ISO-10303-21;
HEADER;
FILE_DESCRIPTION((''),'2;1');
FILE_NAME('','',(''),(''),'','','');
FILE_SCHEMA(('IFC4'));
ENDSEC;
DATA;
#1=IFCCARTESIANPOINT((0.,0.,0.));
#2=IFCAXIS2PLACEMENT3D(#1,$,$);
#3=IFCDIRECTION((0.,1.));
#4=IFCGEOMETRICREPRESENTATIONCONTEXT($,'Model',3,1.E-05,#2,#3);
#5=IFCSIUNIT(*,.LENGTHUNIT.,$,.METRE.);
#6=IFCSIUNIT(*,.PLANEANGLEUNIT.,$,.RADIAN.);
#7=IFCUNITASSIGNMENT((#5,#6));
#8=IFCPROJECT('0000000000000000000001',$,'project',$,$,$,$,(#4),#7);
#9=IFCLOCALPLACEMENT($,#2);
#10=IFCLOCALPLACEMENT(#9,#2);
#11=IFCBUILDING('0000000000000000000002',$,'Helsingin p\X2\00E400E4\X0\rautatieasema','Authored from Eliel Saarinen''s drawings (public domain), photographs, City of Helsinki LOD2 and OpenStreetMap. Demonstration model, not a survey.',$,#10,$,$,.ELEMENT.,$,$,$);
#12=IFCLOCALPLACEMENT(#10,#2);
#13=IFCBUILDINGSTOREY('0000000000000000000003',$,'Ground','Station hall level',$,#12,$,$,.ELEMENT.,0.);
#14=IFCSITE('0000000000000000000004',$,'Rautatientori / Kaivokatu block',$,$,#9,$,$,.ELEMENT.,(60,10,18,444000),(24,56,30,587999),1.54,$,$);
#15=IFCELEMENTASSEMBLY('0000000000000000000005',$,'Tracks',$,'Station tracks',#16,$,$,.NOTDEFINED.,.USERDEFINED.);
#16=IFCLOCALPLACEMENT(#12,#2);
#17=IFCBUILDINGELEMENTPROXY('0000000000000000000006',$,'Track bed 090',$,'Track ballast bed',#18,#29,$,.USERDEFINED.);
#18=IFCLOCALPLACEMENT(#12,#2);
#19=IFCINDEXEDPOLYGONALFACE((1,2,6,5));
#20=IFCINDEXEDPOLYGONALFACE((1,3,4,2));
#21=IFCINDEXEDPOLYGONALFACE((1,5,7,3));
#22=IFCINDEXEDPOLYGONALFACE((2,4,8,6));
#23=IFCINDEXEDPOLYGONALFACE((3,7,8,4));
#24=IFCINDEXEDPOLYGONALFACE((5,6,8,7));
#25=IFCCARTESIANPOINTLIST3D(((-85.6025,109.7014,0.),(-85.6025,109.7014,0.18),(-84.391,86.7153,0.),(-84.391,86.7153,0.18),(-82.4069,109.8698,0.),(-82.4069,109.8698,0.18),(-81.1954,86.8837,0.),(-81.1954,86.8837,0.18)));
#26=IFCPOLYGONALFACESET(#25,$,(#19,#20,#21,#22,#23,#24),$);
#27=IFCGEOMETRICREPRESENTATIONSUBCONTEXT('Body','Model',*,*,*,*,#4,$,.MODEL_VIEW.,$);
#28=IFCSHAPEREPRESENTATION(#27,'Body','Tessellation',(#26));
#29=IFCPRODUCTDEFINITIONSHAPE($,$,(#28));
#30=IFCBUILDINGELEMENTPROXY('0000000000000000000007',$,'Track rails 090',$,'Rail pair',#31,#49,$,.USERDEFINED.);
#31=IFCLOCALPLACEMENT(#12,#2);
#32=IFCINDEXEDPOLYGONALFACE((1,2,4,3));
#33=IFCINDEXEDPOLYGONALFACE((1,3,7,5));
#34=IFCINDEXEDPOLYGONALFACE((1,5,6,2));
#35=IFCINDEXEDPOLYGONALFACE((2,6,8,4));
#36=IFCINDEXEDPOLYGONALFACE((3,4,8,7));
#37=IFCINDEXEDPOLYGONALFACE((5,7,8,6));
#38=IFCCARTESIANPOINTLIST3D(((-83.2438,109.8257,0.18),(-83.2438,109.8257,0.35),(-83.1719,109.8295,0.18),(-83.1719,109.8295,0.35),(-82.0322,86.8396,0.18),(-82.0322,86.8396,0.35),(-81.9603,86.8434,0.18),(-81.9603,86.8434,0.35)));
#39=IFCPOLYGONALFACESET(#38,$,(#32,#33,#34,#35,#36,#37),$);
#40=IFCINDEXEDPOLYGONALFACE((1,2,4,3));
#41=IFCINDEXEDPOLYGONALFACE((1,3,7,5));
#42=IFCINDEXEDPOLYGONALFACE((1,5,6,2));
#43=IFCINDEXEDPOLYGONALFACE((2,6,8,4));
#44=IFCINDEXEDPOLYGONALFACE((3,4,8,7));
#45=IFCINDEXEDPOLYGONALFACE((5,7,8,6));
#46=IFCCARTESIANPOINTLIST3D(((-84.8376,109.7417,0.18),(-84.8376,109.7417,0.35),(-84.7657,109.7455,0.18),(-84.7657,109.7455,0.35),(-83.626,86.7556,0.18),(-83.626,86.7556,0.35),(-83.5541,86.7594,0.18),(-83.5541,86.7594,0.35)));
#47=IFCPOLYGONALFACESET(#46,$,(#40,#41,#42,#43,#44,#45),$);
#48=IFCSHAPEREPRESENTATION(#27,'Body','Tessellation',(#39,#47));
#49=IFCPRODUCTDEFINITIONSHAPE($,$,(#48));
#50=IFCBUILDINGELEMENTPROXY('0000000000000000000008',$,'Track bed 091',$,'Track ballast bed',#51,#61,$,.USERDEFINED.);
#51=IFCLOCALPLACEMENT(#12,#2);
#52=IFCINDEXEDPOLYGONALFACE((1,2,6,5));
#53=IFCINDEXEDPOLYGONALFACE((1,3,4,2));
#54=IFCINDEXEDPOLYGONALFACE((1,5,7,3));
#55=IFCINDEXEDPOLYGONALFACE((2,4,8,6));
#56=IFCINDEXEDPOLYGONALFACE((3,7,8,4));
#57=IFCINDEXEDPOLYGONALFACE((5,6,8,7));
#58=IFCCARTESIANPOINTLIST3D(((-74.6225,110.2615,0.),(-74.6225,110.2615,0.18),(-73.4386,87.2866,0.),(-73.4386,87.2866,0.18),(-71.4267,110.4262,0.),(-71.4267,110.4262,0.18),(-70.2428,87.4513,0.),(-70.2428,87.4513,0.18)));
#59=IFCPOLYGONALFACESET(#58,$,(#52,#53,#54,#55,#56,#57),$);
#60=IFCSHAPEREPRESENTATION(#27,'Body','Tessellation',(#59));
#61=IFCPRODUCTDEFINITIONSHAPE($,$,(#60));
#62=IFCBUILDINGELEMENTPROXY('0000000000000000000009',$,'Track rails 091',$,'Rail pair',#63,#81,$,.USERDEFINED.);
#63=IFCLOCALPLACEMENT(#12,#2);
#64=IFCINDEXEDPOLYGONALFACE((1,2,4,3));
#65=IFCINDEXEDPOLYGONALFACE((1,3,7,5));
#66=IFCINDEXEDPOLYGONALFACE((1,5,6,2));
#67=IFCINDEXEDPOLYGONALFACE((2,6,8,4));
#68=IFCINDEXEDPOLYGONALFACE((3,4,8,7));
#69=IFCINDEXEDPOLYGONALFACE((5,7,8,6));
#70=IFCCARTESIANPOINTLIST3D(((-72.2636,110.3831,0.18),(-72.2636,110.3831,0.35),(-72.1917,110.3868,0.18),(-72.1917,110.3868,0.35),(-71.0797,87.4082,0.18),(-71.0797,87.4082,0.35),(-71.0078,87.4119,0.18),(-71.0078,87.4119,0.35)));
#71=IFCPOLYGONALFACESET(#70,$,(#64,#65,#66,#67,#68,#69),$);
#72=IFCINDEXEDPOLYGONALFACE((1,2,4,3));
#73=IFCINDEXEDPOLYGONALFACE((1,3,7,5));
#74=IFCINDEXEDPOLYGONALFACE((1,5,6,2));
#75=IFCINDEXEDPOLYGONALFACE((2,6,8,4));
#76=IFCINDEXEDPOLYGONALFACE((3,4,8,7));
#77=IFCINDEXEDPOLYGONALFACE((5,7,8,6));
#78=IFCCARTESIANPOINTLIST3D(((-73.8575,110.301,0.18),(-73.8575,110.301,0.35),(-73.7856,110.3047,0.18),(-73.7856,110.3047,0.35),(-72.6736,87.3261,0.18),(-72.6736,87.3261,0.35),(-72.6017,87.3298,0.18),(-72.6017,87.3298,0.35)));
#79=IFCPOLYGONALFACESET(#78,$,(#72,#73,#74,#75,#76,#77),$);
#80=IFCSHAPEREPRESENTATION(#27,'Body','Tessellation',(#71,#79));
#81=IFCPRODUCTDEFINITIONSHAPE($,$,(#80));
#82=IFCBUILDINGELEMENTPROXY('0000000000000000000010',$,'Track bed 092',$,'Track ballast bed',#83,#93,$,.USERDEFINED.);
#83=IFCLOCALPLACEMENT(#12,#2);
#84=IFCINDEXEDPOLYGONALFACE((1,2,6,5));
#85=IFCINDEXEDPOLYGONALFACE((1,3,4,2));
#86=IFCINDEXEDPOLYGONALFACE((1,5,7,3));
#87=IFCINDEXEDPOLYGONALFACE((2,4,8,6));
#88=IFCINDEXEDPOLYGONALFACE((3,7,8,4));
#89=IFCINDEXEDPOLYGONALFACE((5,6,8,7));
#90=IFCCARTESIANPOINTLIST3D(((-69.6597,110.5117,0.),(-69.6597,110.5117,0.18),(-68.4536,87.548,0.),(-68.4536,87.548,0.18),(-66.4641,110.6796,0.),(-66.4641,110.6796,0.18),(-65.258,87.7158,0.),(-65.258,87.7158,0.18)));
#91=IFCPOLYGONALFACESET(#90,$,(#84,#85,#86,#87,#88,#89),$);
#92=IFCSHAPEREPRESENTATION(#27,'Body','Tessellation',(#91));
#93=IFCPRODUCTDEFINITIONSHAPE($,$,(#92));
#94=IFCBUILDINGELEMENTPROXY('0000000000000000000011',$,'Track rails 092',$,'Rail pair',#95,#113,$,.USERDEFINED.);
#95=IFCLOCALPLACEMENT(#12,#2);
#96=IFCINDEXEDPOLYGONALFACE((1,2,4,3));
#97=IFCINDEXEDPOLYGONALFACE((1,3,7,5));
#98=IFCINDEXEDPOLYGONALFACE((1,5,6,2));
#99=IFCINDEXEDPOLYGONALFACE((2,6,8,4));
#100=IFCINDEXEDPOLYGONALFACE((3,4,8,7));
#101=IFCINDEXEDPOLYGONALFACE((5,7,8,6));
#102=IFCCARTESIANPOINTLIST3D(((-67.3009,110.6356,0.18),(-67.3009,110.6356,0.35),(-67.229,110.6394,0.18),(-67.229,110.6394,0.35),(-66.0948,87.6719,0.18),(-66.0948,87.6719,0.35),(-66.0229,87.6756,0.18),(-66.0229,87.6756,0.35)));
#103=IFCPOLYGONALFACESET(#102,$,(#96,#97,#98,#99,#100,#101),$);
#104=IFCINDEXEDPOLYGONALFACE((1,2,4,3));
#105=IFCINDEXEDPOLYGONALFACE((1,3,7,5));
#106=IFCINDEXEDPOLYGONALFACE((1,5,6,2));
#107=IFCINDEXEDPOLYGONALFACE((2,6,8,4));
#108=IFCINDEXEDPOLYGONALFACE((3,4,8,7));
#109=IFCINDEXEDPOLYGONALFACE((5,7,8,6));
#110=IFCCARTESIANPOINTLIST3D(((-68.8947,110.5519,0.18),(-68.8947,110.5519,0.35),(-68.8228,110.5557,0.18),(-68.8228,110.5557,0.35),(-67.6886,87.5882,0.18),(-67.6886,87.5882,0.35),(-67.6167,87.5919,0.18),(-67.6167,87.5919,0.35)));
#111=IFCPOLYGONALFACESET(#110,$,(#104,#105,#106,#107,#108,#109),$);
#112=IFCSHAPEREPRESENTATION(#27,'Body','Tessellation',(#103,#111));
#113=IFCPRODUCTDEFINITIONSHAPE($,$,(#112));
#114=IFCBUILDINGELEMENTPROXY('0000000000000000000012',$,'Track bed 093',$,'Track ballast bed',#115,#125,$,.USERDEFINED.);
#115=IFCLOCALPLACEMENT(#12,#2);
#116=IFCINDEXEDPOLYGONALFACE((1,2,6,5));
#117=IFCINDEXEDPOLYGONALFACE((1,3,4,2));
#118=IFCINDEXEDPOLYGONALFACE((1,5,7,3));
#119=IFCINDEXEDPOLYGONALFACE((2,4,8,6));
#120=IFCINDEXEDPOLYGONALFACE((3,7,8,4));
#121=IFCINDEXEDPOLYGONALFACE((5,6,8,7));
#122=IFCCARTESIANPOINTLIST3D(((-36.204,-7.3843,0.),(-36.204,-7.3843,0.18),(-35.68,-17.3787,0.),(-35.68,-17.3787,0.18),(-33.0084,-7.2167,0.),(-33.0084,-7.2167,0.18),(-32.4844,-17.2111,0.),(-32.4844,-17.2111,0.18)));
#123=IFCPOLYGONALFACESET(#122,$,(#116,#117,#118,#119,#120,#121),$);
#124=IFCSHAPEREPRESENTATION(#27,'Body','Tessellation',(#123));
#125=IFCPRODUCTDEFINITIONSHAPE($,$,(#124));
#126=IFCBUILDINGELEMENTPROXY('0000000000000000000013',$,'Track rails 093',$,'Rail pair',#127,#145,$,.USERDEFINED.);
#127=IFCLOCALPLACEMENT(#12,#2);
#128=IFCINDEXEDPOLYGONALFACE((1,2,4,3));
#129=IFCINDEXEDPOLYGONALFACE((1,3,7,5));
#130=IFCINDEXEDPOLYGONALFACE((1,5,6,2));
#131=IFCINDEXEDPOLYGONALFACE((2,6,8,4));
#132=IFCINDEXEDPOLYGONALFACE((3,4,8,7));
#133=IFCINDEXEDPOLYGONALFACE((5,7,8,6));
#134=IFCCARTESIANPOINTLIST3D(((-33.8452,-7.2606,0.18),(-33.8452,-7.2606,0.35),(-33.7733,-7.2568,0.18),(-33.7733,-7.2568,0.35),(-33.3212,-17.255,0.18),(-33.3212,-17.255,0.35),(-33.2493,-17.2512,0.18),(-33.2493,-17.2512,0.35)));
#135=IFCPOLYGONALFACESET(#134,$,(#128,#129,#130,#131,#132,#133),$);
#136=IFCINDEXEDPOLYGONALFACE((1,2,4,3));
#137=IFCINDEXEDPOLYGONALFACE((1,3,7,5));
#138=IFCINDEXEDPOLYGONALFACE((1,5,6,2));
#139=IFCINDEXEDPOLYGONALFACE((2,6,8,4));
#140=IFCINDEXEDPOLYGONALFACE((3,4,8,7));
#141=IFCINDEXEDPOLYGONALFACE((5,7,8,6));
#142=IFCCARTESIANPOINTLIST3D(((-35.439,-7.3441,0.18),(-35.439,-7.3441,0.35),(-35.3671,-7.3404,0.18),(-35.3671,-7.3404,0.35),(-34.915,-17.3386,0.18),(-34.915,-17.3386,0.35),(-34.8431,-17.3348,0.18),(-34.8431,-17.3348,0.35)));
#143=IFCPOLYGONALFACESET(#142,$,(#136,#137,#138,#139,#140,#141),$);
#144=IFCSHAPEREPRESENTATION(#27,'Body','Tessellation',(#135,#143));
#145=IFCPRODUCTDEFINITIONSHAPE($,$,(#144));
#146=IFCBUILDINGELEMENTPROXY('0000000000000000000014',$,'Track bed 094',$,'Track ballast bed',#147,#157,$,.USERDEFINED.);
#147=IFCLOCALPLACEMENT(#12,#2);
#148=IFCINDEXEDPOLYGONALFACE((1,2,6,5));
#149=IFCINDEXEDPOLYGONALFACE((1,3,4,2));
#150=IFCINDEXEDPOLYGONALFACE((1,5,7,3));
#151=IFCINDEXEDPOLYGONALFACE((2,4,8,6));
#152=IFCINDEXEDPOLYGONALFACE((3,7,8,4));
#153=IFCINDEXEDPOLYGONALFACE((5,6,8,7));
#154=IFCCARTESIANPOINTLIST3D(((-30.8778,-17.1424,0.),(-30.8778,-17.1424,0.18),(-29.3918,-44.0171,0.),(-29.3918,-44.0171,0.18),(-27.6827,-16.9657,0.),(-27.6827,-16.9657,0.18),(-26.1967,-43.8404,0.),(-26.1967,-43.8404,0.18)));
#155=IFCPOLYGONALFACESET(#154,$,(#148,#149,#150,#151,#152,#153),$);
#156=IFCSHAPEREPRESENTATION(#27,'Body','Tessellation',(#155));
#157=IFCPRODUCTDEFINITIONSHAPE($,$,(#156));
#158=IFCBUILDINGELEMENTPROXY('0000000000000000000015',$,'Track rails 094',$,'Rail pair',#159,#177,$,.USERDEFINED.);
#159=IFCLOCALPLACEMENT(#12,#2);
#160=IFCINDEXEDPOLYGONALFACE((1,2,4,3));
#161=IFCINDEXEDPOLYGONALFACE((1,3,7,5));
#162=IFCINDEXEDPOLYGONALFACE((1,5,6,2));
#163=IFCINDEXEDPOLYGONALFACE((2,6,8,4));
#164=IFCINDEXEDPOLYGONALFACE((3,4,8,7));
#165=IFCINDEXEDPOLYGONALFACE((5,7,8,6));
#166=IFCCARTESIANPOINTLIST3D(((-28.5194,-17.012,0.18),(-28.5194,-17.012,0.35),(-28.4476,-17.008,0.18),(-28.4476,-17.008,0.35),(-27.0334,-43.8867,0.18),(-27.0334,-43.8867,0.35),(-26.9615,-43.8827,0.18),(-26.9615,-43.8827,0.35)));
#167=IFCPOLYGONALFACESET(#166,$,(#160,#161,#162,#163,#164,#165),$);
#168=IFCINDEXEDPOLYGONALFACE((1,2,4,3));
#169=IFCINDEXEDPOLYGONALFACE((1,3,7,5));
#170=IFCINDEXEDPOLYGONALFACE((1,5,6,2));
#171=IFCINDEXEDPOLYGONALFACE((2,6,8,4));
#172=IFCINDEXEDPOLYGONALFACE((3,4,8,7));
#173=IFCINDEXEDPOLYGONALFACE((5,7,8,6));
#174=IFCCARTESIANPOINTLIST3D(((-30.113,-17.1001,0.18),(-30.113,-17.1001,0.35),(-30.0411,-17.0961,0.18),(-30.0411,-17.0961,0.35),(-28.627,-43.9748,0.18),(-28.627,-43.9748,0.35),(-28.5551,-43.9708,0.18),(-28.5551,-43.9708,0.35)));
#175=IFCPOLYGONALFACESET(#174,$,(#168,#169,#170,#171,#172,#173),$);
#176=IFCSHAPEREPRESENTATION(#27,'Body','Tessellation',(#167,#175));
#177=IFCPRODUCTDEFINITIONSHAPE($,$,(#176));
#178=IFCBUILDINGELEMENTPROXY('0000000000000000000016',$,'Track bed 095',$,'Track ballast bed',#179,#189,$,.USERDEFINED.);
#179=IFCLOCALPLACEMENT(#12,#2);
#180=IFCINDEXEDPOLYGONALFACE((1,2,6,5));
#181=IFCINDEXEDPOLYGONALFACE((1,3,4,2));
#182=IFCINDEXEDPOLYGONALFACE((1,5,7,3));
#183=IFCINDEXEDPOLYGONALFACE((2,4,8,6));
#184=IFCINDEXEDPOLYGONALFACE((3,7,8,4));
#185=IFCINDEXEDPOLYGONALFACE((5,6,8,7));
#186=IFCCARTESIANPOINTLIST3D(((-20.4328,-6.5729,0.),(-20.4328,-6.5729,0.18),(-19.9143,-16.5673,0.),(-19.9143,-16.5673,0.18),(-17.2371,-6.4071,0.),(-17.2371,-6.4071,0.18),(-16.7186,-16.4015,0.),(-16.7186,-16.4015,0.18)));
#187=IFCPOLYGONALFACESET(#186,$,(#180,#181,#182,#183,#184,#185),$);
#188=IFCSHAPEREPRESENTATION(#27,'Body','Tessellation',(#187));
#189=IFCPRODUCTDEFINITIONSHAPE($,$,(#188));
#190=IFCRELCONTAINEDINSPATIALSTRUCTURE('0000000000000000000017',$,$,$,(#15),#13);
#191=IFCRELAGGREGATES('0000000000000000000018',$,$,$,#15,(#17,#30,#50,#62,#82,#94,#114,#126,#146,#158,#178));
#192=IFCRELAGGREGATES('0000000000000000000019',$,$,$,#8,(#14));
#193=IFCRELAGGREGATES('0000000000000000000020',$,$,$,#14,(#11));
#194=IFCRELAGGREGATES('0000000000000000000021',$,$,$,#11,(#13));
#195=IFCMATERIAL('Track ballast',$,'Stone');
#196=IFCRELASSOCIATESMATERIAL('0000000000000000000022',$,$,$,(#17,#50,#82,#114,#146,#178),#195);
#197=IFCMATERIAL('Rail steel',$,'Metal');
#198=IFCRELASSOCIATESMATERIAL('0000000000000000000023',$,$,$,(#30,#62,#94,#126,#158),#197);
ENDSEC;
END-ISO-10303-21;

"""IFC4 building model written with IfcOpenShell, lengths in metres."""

from ifc_helpers import new_model, si_unit, direction, frame, origin, place, context, subcontext, project, spatial, polyline, outline, extrude, material, element, aggregate, save


model = new_model("IFC4")

# Units and contexts
model_context = context("Model", 3, precision=1e-05, world=origin(), true_north=direction((0.0, 1.0)))
body_context = subcontext(model_context, "Body", "Model", "MODEL_VIEW")
ifc_project = project(units=[si_unit("LENGTHUNIT", "METRE"), si_unit("PLANEANGLEUNIT", "RADIAN")], contexts=[model_context])

# Site, building, storey
site_placement = place(None, origin())
site = spatial("IfcSite", under=ifc_project, at=site_placement, Name="Rautatientori / Kaivokatu block", CompositionType="ELEMENT", RefLatitude=(60, 10, 18, 444000), RefLongitude=(24, 56, 30, 587999), RefElevation=1.54)
building_placement = place(site_placement, origin())
building = spatial("IfcBuilding", under=site, at=building_placement, Name="Helsingin päärautatieasema", Description="Authored from Eliel Saarinen's drawings (public domain), photographs, City of Helsinki LOD2 and OpenStreetMap. Demonstration model, not a survey.", CompositionType="ELEMENT")
storey_placement = place(building_placement, origin())
storey = spatial("IfcBuildingStorey", under=building, at=storey_placement, Name="Ground", Description="Station hall level", CompositionType="ELEMENT", Elevation=0.0)

# Element assembly, building element proxies
assembly_placement = place(building_placement, origin())
assembly = element("IfcElementAssembly", 1, at=assembly_placement, inside=storey, Name="Tracks", ObjectType="Station tracks", AssemblyPlace="NOTDEFINED", PredefinedType="USERDEFINED")
ifc_material_1 = material(Name="Track ballast", Category="Stone")
proxy_1_placement = place(building_placement, origin())
proxy_1 = element("IfcBuildingElementProxy", 2, at=proxy_1_placement, material=ifc_material_1, Name="Track bed 090", ObjectType="Track ballast bed", PredefinedType="USERDEFINED", context=body_context, shape_type="SweptSolid", body=[
    extrude(outline(polyline([(-85.6025, 109.7014), (-82.4069, 109.8698), (-81.1954, 86.8837), (-84.391, 86.7153), (-85.6025, 109.7014)])), origin(), (0.0, 0.0, 1.0), 0.18),
])
ifc_material_2 = material(Name="Rail steel", Category="Metal")
proxy_2_placement = place(building_placement, origin())
proxy_2 = element("IfcBuildingElementProxy", 3, at=proxy_2_placement, material=ifc_material_2, Name="Track rails 090", ObjectType="Rail pair", PredefinedType="USERDEFINED", context=body_context, shape_type="SweptSolid", body=[
    extrude(outline(polyline([(-83.2438, 109.8257), (-83.1719, 109.8295), (-81.9603, 86.8434), (-82.0322, 86.8396), (-83.2438, 109.8257)])), frame((0.0, 0.0, 0.18)), (0.0, 0.0, 1.0), 0.17),
    extrude(outline(polyline([(-84.8376, 109.7417), (-84.7657, 109.7455), (-83.5541, 86.7594), (-83.626, 86.7556), (-84.8376, 109.7417)])), frame((0.0, 0.0, 0.18)), (0.0, 0.0, 1.0), 0.17),
])
proxy_3_placement = place(building_placement, origin())
proxy_3 = element("IfcBuildingElementProxy", 4, at=proxy_3_placement, material=ifc_material_1, Name="Track bed 091", ObjectType="Track ballast bed", PredefinedType="USERDEFINED", context=body_context, shape_type="SweptSolid", body=[
    extrude(outline(polyline([(-74.6225, 110.2615), (-71.4267, 110.4262), (-70.2428, 87.4513), (-73.4386, 87.2866), (-74.6225, 110.2615)])), origin(), (0.0, 0.0, 1.0), 0.18),
])
proxy_4_placement = place(building_placement, origin())
proxy_4 = element("IfcBuildingElementProxy", 5, at=proxy_4_placement, material=ifc_material_2, Name="Track rails 091", ObjectType="Rail pair", PredefinedType="USERDEFINED", context=body_context, shape_type="SweptSolid", body=[
    extrude(outline(polyline([(-72.2636, 110.3831), (-72.1917, 110.3868), (-71.0078, 87.4119), (-71.0797, 87.4082), (-72.2636, 110.3831)])), frame((0.0, 0.0, 0.18)), (0.0, 0.0, 1.0), 0.17),
    extrude(outline(polyline([(-73.8575, 110.301), (-73.7856, 110.3047), (-72.6017, 87.3298), (-72.6736, 87.3261), (-73.8575, 110.301)])), frame((0.0, 0.0, 0.18)), (0.0, 0.0, 1.0), 0.17),
])
proxy_5_placement = place(building_placement, origin())
proxy_5 = element("IfcBuildingElementProxy", 6, at=proxy_5_placement, material=ifc_material_1, Name="Track bed 092", ObjectType="Track ballast bed", PredefinedType="USERDEFINED", context=body_context, shape_type="SweptSolid", body=[
    extrude(outline(polyline([(-69.6597, 110.5117), (-66.4641, 110.6796), (-65.258, 87.7158), (-68.4536, 87.548), (-69.6597, 110.5117)])), origin(), (0.0, 0.0, 1.0), 0.18),
])
proxy_6_placement = place(building_placement, origin())
proxy_6 = element("IfcBuildingElementProxy", 7, at=proxy_6_placement, material=ifc_material_2, Name="Track rails 092", ObjectType="Rail pair", PredefinedType="USERDEFINED", context=body_context, shape_type="SweptSolid", body=[
    extrude(outline(polyline([(-67.3009, 110.6356), (-67.229, 110.6394), (-66.0229, 87.6756), (-66.0948, 87.6719), (-67.3009, 110.6356)])), frame((0.0, 0.0, 0.18)), (0.0, 0.0, 1.0), 0.17),
    extrude(outline(polyline([(-68.8947, 110.5519), (-68.8228, 110.5557), (-67.6167, 87.5919), (-67.6886, 87.5882), (-68.8947, 110.5519)])), frame((0.0, 0.0, 0.18)), (0.0, 0.0, 1.0), 0.17),
])
proxy_7_placement = place(building_placement, origin())
proxy_7 = element("IfcBuildingElementProxy", 8, at=proxy_7_placement, material=ifc_material_1, Name="Track bed 093", ObjectType="Track ballast bed", PredefinedType="USERDEFINED", context=body_context, shape_type="SweptSolid", body=[
    extrude(outline(polyline([(-36.204, -7.3843), (-33.0084, -7.2167), (-32.4844, -17.2111), (-35.68, -17.3787), (-36.204, -7.3843)])), origin(), (0.0, 0.0, 1.0), 0.18),
])
proxy_8_placement = place(building_placement, origin())
proxy_8 = element("IfcBuildingElementProxy", 9, at=proxy_8_placement, material=ifc_material_2, Name="Track rails 093", ObjectType="Rail pair", PredefinedType="USERDEFINED", context=body_context, shape_type="SweptSolid", body=[
    extrude(outline(polyline([(-33.8452, -7.2606), (-33.7733, -7.2568), (-33.2493, -17.2512), (-33.3212, -17.255), (-33.8452, -7.2606)])), frame((0.0, 0.0, 0.18)), (0.0, 0.0, 1.0), 0.17),
    extrude(outline(polyline([(-35.439, -7.3441), (-35.3671, -7.3404), (-34.8431, -17.3348), (-34.915, -17.3386), (-35.439, -7.3441)])), frame((0.0, 0.0, 0.18)), (0.0, 0.0, 1.0), 0.17),
])
proxy_9_placement = place(building_placement, origin())
proxy_9 = element("IfcBuildingElementProxy", 10, at=proxy_9_placement, material=ifc_material_1, Name="Track bed 094", ObjectType="Track ballast bed", PredefinedType="USERDEFINED", context=body_context, shape_type="SweptSolid", body=[
    extrude(outline(polyline([(-30.8778, -17.1424), (-27.6827, -16.9657), (-26.1967, -43.8404), (-29.3918, -44.0171), (-30.8778, -17.1424)])), origin(), (0.0, 0.0, 1.0), 0.18),
])
proxy_10_placement = place(building_placement, origin())
proxy_10 = element("IfcBuildingElementProxy", 11, at=proxy_10_placement, material=ifc_material_2, Name="Track rails 094", ObjectType="Rail pair", PredefinedType="USERDEFINED", context=body_context, shape_type="SweptSolid", body=[
    extrude(outline(polyline([(-28.5194, -17.012), (-28.4476, -17.008), (-26.9615, -43.8827), (-27.0334, -43.8867), (-28.5194, -17.012)])), frame((0.0, 0.0, 0.18)), (0.0, 0.0, 1.0), 0.17),
    extrude(outline(polyline([(-30.113, -17.1001), (-30.0411, -17.0961), (-28.5551, -43.9708), (-28.627, -43.9748), (-30.113, -17.1001)])), frame((0.0, 0.0, 0.18)), (0.0, 0.0, 1.0), 0.17),
])
proxy_11_placement = place(building_placement, origin())
proxy_11 = element("IfcBuildingElementProxy", 12, at=proxy_11_placement, material=ifc_material_1, Name="Track bed 095", ObjectType="Track ballast bed", PredefinedType="USERDEFINED", context=body_context, shape_type="SweptSolid", body=[
    extrude(outline(polyline([(-20.4328, -6.5729), (-17.2371, -6.4071), (-16.7186, -16.4015), (-19.9143, -16.5673), (-20.4328, -6.5729)])), origin(), (0.0, 0.0, 1.0), 0.18),
])
aggregate(assembly, [proxy_1, proxy_2, proxy_3, proxy_4, proxy_5, proxy_6, proxy_7, proxy_8, proxy_9, proxy_10, proxy_11])

save(model, "model.ifc")
